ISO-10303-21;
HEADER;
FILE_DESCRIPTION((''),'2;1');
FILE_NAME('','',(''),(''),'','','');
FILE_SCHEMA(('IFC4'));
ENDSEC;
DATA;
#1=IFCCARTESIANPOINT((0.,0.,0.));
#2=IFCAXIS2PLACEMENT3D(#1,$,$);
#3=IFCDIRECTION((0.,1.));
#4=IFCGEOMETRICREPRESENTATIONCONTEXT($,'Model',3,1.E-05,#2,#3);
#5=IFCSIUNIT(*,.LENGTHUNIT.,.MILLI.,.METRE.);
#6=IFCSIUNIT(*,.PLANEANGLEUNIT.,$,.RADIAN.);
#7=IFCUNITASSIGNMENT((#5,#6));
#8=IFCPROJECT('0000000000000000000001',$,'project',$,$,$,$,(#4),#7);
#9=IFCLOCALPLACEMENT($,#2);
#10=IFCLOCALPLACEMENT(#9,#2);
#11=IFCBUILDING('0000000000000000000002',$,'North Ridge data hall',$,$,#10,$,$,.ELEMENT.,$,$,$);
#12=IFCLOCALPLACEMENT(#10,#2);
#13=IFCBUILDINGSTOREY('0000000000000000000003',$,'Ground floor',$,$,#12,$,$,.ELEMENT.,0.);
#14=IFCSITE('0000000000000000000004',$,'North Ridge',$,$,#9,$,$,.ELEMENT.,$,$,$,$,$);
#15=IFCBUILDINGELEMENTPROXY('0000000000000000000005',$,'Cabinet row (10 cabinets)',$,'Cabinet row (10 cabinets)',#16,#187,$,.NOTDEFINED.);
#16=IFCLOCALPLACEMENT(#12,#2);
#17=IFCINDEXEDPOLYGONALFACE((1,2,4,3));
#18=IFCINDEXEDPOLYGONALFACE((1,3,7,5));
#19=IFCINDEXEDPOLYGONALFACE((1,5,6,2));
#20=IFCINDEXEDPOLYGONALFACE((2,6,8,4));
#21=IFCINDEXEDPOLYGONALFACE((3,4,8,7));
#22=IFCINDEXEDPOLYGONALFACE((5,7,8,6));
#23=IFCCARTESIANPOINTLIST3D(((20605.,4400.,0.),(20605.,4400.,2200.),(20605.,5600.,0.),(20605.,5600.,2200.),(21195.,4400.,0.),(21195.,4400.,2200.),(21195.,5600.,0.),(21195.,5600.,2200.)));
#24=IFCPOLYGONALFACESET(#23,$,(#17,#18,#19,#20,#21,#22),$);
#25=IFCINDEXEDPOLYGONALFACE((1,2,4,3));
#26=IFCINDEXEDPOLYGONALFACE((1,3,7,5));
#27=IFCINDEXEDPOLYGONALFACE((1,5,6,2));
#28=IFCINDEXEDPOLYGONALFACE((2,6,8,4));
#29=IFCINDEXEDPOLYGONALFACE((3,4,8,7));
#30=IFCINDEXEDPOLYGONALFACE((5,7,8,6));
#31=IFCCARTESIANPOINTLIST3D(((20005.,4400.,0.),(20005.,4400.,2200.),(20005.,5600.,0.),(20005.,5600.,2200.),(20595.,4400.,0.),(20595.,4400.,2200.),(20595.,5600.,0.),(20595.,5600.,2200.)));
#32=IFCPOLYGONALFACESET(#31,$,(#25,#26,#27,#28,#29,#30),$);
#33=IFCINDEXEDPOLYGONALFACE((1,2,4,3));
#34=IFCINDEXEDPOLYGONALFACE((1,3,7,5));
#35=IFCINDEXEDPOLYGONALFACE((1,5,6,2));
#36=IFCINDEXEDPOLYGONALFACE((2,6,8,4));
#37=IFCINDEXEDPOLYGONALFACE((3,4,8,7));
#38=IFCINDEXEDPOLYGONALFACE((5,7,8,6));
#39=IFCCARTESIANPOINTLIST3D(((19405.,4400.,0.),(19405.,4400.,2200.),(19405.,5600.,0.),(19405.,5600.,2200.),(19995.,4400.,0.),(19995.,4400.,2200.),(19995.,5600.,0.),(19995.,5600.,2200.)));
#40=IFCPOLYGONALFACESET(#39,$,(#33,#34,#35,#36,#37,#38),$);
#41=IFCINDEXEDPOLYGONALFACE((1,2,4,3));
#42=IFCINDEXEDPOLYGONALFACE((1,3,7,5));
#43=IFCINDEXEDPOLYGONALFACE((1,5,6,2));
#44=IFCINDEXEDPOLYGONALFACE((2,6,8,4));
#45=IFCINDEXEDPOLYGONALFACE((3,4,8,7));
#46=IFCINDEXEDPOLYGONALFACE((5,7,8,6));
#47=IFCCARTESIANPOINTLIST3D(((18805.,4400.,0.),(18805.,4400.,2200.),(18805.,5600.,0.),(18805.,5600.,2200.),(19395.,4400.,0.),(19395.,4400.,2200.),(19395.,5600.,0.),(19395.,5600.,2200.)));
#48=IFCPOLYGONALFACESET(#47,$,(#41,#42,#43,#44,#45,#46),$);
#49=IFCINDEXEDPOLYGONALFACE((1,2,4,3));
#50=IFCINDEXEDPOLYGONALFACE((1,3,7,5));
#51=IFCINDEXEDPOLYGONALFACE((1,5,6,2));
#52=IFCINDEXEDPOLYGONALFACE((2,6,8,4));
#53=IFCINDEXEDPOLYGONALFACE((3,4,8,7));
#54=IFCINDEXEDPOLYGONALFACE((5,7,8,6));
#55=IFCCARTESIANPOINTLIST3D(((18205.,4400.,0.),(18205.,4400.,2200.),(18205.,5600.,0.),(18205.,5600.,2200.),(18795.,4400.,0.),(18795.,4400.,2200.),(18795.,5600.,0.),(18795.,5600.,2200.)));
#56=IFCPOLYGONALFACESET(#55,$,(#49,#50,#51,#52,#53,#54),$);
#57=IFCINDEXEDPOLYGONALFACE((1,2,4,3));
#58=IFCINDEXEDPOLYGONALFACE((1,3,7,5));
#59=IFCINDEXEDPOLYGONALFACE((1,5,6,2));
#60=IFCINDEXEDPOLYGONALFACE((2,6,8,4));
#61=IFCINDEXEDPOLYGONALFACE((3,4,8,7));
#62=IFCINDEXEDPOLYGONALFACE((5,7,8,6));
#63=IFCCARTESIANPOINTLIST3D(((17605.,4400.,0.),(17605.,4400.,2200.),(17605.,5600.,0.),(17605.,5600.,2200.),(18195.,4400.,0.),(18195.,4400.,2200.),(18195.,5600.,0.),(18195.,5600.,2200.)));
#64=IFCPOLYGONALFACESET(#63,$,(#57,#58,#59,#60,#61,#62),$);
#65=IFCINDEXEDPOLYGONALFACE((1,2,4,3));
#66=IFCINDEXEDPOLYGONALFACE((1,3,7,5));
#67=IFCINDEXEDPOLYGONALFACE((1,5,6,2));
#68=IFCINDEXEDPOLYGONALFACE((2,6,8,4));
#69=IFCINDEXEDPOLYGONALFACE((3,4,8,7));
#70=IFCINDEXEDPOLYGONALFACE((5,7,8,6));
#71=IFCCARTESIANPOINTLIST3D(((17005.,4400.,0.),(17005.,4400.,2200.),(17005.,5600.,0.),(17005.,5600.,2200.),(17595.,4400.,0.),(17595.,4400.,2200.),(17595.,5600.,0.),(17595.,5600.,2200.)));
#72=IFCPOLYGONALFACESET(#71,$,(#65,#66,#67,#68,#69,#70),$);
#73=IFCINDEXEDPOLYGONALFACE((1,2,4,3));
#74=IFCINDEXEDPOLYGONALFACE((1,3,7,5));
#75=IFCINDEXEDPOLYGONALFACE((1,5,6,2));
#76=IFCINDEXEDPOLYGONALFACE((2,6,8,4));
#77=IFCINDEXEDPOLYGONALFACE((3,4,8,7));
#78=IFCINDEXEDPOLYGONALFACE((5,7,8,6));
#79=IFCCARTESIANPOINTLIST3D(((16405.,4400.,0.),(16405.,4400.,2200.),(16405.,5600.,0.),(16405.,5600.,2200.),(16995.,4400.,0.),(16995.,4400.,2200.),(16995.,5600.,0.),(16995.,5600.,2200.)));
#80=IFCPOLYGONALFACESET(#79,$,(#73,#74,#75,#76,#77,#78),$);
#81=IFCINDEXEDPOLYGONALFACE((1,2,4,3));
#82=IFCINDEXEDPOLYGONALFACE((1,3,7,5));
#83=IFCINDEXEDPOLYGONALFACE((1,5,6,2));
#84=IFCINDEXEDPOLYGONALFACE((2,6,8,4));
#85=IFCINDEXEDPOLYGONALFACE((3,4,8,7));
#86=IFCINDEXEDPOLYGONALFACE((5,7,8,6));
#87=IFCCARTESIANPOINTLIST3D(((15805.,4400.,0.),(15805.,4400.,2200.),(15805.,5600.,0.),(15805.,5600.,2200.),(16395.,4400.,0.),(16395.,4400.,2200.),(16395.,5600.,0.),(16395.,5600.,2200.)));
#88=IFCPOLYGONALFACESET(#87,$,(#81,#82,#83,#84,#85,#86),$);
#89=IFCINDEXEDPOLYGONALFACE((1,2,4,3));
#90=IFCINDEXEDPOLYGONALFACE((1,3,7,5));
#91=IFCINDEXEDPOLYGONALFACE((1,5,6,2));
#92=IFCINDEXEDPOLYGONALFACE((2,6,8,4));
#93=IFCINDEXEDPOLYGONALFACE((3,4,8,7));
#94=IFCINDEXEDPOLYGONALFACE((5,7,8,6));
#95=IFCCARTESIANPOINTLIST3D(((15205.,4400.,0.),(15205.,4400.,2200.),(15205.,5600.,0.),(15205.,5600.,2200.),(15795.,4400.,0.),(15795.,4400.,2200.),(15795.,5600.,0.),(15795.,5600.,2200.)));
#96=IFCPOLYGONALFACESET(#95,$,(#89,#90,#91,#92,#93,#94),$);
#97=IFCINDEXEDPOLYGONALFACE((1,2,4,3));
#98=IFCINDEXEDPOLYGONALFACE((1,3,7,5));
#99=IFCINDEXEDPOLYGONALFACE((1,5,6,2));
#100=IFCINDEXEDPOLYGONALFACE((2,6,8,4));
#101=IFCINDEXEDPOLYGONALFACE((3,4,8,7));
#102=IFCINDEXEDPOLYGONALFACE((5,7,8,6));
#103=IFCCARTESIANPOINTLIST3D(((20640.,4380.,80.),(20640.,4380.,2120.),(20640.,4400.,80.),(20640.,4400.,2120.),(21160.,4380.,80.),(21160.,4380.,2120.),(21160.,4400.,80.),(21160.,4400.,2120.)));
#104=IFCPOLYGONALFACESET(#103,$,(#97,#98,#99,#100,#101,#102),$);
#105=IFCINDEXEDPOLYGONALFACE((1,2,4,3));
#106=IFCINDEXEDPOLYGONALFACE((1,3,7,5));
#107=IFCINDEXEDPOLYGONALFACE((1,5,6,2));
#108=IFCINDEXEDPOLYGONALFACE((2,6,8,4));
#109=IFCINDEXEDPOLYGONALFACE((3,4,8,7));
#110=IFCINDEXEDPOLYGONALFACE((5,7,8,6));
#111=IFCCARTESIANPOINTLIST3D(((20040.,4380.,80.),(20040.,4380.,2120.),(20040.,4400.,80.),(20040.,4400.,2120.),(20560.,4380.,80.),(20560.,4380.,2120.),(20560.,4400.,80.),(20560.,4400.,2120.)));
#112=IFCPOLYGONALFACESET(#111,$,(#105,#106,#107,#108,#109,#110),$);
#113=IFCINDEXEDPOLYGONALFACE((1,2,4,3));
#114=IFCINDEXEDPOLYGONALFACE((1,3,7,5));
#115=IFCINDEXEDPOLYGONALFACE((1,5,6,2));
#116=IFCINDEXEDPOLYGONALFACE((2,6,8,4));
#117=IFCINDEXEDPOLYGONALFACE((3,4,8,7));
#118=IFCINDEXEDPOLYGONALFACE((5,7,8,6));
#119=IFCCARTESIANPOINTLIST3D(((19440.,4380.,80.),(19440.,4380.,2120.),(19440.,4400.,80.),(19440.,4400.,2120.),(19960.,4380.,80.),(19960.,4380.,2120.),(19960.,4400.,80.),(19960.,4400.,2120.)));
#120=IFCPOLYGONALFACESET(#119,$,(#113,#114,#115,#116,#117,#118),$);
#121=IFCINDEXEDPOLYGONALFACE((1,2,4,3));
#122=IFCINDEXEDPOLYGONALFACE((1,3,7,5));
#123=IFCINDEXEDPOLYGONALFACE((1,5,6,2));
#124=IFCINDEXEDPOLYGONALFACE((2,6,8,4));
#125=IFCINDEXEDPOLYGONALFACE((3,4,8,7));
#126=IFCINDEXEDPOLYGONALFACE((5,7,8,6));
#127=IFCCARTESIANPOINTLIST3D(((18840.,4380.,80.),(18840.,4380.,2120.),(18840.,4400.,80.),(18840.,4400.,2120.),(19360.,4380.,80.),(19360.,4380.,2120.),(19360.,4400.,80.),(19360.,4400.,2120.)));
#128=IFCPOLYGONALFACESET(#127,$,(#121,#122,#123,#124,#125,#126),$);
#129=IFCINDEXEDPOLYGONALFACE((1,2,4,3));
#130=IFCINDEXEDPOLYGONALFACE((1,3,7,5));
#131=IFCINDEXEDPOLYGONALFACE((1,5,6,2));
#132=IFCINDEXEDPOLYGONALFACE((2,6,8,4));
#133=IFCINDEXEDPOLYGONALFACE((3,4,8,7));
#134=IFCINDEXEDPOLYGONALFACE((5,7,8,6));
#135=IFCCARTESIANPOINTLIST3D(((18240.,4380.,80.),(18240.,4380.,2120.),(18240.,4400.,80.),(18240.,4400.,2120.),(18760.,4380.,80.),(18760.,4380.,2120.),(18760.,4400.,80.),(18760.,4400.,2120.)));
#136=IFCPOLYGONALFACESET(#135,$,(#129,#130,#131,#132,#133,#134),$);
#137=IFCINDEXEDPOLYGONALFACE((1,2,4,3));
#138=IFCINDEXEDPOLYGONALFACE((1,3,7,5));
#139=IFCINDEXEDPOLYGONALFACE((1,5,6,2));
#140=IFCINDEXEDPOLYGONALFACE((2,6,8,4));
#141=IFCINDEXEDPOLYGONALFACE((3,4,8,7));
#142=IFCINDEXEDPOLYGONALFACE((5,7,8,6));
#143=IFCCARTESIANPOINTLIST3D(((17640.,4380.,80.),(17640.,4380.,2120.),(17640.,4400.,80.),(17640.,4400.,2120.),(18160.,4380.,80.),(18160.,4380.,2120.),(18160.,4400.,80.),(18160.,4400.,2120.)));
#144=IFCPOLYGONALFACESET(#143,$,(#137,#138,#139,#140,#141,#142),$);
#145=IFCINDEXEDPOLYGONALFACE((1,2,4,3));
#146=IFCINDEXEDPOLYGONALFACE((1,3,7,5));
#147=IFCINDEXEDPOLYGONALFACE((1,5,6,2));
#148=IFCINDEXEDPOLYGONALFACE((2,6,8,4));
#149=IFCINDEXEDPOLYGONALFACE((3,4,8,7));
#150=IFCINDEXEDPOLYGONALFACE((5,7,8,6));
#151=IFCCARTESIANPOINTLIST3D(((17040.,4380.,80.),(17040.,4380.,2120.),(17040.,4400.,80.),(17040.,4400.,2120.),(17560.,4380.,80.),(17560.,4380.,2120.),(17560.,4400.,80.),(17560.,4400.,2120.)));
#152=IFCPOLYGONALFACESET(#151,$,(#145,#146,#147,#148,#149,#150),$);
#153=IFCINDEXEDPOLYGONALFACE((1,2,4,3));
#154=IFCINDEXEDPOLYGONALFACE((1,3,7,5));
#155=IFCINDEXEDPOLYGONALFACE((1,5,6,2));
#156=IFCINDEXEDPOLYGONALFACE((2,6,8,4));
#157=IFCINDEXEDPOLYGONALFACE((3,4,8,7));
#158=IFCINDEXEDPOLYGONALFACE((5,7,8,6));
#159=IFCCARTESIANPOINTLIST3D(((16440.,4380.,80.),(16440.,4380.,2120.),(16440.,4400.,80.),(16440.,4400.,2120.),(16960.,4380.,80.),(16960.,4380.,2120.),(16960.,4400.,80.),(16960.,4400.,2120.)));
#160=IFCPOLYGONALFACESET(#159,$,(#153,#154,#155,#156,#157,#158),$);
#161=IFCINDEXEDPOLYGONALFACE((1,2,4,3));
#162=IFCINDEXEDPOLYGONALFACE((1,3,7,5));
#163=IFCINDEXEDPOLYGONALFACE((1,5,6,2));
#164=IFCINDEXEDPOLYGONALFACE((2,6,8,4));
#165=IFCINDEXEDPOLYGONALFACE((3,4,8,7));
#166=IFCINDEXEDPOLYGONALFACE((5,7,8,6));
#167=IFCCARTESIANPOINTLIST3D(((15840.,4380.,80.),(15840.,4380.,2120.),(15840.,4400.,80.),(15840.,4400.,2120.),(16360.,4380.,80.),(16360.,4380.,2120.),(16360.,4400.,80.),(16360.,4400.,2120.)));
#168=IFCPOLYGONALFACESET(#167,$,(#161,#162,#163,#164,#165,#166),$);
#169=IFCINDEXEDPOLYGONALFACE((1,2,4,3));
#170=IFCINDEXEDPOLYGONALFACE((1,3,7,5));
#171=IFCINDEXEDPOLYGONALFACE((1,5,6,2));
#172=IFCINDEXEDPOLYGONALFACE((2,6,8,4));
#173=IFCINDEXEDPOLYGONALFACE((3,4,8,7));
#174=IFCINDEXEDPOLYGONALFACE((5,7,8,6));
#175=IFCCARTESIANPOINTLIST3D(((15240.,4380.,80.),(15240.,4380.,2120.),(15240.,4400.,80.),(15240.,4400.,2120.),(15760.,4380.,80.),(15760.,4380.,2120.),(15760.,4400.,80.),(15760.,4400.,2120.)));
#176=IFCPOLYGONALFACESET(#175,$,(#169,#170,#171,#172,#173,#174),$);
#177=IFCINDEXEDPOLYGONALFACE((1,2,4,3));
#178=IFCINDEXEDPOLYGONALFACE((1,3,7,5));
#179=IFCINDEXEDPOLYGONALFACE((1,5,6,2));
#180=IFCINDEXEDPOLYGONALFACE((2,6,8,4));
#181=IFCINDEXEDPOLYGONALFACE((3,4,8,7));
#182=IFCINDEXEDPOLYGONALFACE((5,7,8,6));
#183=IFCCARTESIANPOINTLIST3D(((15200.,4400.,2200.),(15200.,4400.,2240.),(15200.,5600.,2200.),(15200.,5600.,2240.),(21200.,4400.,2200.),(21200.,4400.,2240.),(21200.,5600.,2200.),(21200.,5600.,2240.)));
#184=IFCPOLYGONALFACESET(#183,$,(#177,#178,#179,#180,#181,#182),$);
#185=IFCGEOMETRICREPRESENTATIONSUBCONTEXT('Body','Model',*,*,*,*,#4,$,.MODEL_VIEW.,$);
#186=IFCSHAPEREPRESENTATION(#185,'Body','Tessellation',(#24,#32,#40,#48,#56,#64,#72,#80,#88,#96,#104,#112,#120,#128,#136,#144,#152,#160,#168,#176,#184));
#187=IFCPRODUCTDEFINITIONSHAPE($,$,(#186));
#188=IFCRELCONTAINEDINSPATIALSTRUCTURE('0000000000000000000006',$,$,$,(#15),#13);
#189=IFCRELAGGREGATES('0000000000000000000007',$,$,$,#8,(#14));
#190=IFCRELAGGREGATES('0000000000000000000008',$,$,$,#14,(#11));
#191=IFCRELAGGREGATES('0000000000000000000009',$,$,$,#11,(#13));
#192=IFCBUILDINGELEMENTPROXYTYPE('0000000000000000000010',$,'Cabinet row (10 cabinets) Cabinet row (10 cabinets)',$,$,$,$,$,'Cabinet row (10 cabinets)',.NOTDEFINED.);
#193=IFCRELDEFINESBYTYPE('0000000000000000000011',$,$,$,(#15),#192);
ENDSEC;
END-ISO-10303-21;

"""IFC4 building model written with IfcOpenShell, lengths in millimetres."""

from ifc_helpers import new_model, si_unit, direction, frame, origin, place, context, subcontext, project, spatial, polyline, outline, extrude, source, transform, mapped, type_object, type_shapes, element, save


model = new_model("IFC4")

# Units and contexts
model_context = context("Model", 3, precision=1e-05, world=origin(), true_north=direction((0.0, 1.0)))
body_context = subcontext(model_context, "Body", "Model", "MODEL_VIEW")
ifc_project = project(units=[si_unit("LENGTHUNIT", "METRE", prefix="MILLI"), si_unit("PLANEANGLEUNIT", "RADIAN")], contexts=[model_context])

# Site, building, storey
site_placement = place(None, origin())
site = spatial("IfcSite", under=ifc_project, at=site_placement, Name="North Ridge", CompositionType="ELEMENT")
building_placement = place(site_placement, origin())
building = spatial("IfcBuilding", under=site, at=building_placement, Name="North Ridge data hall", CompositionType="ELEMENT")
storey_placement = place(building_placement, origin())
storey = spatial("IfcBuildingStorey", under=building, at=storey_placement, Name="Ground floor", CompositionType="ELEMENT", Elevation=0.0)

# Building element proxy
building_element_proxy_type_1 = type_object("IfcBuildingElementProxyType", Name="Cabinet row (10 cabinets) Cabinet row (10 cabinets)", ElementType="Cabinet row (10 cabinets)", PredefinedType="NOTDEFINED")
shared_shape_1 = source(origin(), body_context, "Body", "SweptSolid", [
    extrude(outline(polyline([(5.0, 0.0), (595.0, 0.0), (595.0, 1200.0), (5.0, 1200.0), (5.0, 0.0)])), origin(), (0.0, 0.0, 1.0), 2200.0),
    extrude(outline(polyline([(605.0, 0.0), (1195.0, 0.0), (1195.0, 1200.0), (605.0, 1200.0), (605.0, 0.0)])), origin(), (0.0, 0.0, 1.0), 2200.0),
    extrude(outline(polyline([(1205.0, 0.0), (1795.0, 0.0), (1795.0, 1200.0), (1205.0, 1200.0), (1205.0, 0.0)])), origin(), (0.0, 0.0, 1.0), 2200.0),
    extrude(outline(polyline([(1805.0, 0.0), (2395.0, 0.0), (2395.0, 1200.0), (1805.0, 1200.0), (1805.0, 0.0)])), origin(), (0.0, 0.0, 1.0), 2200.0),
    extrude(outline(polyline([(2405.0, 0.0), (2995.0, 0.0), (2995.0, 1200.0), (2405.0, 1200.0), (2405.0, 0.0)])), origin(), (0.0, 0.0, 1.0), 2200.0),
    extrude(outline(polyline([(3005.0, 0.0), (3595.0, 0.0), (3595.0, 1200.0), (3005.0, 1200.0), (3005.0, 0.0)])), origin(), (0.0, 0.0, 1.0), 2200.0),
    extrude(outline(polyline([(3605.0, 0.0), (4195.0, 0.0), (4195.0, 1200.0), (3605.0, 1200.0), (3605.0, 0.0)])), origin(), (0.0, 0.0, 1.0), 2200.0),
    extrude(outline(polyline([(4205.0, 0.0), (4795.0, 0.0), (4795.0, 1200.0), (4205.0, 1200.0), (4205.0, 0.0)])), origin(), (0.0, 0.0, 1.0), 2200.0),
    extrude(outline(polyline([(4805.0, 0.0), (5395.0, 0.0), (5395.0, 1200.0), (4805.0, 1200.0), (4805.0, 0.0)])), origin(), (0.0, 0.0, 1.0), 2200.0),
    extrude(outline(polyline([(5405.0, 0.0), (5995.0, 0.0), (5995.0, 1200.0), (5405.0, 1200.0), (5405.0, 0.0)])), origin(), (0.0, 0.0, 1.0), 2200.0),
    extrude(outline(polyline([(40.0, 1200.0), (560.0, 1200.0), (560.0, 1220.0), (40.0, 1220.0), (40.0, 1200.0)])), frame((0.0, 0.0, 80.0)), (0.0, 0.0, 1.0), 2040.0),
    extrude(outline(polyline([(640.0, 1200.0), (1160.0, 1200.0), (1160.0, 1220.0), (640.0, 1220.0), (640.0, 1200.0)])), frame((0.0, 0.0, 80.0)), (0.0, 0.0, 1.0), 2040.0),
    extrude(outline(polyline([(1240.0, 1200.0), (1760.0, 1200.0), (1760.0, 1220.0), (1240.0, 1220.0), (1240.0, 1200.0)])), frame((0.0, 0.0, 80.0)), (0.0, 0.0, 1.0), 2040.0),
    extrude(outline(polyline([(1840.0, 1200.0), (2360.0, 1200.0), (2360.0, 1220.0), (1840.0, 1220.0), (1840.0, 1200.0)])), frame((0.0, 0.0, 80.0)), (0.0, 0.0, 1.0), 2040.0),
    extrude(outline(polyline([(2440.0, 1200.0), (2960.0, 1200.0), (2960.0, 1220.0), (2440.0, 1220.0), (2440.0, 1200.0)])), frame((0.0, 0.0, 80.0)), (0.0, 0.0, 1.0), 2040.0),
    extrude(outline(polyline([(3040.0, 1200.0), (3560.0, 1200.0), (3560.0, 1220.0), (3040.0, 1220.0), (3040.0, 1200.0)])), frame((0.0, 0.0, 80.0)), (0.0, 0.0, 1.0), 2040.0),
    extrude(outline(polyline([(3640.0, 1200.0), (4160.0, 1200.0), (4160.0, 1220.0), (3640.0, 1220.0), (3640.0, 1200.0)])), frame((0.0, 0.0, 80.0)), (0.0, 0.0, 1.0), 2040.0),
    extrude(outline(polyline([(4240.0, 1200.0), (4760.0, 1200.0), (4760.0, 1220.0), (4240.0, 1220.0), (4240.0, 1200.0)])), frame((0.0, 0.0, 80.0)), (0.0, 0.0, 1.0), 2040.0),
    extrude(outline(polyline([(4840.0, 1200.0), (5360.0, 1200.0), (5360.0, 1220.0), (4840.0, 1220.0), (4840.0, 1200.0)])), frame((0.0, 0.0, 80.0)), (0.0, 0.0, 1.0), 2040.0),
    extrude(outline(polyline([(5440.0, 1200.0), (5960.0, 1200.0), (5960.0, 1220.0), (5440.0, 1220.0), (5440.0, 1200.0)])), frame((0.0, 0.0, 80.0)), (0.0, 0.0, 1.0), 2040.0),
    extrude(outline(polyline([(0.0, 0.0), (6000.0, 0.0), (6000.0, 1200.0), (0.0, 1200.0), (0.0, 0.0)])), frame((0.0, 0.0, 2200.0)), (0.0, 0.0, 1.0), 40.0),
])
type_shapes(building_element_proxy_type_1, [shared_shape_1])
for number, where, z_axis, x_axis, name in (
    (1, (21200.0, 5600.0, 0.0), (0.0, 0.0, 1.0), (-1.0, 0.0, 0.0), "Cabinet row (10 cabinets)"),
):
    element("IfcBuildingElementProxy", number, at=place(storey_placement, frame(where, z_axis=z_axis, x_axis=x_axis)), inside=storey, type_object=building_element_proxy_type_1, Name=name, ObjectType="Cabinet row (10 cabinets)", PredefinedType="NOTDEFINED", context=body_context, shape_type="MappedRepresentation", body=[
        mapped(shared_shape_1, transform((0.0, 0.0, 0.0))),
    ])

save(model, "model.ifc")
